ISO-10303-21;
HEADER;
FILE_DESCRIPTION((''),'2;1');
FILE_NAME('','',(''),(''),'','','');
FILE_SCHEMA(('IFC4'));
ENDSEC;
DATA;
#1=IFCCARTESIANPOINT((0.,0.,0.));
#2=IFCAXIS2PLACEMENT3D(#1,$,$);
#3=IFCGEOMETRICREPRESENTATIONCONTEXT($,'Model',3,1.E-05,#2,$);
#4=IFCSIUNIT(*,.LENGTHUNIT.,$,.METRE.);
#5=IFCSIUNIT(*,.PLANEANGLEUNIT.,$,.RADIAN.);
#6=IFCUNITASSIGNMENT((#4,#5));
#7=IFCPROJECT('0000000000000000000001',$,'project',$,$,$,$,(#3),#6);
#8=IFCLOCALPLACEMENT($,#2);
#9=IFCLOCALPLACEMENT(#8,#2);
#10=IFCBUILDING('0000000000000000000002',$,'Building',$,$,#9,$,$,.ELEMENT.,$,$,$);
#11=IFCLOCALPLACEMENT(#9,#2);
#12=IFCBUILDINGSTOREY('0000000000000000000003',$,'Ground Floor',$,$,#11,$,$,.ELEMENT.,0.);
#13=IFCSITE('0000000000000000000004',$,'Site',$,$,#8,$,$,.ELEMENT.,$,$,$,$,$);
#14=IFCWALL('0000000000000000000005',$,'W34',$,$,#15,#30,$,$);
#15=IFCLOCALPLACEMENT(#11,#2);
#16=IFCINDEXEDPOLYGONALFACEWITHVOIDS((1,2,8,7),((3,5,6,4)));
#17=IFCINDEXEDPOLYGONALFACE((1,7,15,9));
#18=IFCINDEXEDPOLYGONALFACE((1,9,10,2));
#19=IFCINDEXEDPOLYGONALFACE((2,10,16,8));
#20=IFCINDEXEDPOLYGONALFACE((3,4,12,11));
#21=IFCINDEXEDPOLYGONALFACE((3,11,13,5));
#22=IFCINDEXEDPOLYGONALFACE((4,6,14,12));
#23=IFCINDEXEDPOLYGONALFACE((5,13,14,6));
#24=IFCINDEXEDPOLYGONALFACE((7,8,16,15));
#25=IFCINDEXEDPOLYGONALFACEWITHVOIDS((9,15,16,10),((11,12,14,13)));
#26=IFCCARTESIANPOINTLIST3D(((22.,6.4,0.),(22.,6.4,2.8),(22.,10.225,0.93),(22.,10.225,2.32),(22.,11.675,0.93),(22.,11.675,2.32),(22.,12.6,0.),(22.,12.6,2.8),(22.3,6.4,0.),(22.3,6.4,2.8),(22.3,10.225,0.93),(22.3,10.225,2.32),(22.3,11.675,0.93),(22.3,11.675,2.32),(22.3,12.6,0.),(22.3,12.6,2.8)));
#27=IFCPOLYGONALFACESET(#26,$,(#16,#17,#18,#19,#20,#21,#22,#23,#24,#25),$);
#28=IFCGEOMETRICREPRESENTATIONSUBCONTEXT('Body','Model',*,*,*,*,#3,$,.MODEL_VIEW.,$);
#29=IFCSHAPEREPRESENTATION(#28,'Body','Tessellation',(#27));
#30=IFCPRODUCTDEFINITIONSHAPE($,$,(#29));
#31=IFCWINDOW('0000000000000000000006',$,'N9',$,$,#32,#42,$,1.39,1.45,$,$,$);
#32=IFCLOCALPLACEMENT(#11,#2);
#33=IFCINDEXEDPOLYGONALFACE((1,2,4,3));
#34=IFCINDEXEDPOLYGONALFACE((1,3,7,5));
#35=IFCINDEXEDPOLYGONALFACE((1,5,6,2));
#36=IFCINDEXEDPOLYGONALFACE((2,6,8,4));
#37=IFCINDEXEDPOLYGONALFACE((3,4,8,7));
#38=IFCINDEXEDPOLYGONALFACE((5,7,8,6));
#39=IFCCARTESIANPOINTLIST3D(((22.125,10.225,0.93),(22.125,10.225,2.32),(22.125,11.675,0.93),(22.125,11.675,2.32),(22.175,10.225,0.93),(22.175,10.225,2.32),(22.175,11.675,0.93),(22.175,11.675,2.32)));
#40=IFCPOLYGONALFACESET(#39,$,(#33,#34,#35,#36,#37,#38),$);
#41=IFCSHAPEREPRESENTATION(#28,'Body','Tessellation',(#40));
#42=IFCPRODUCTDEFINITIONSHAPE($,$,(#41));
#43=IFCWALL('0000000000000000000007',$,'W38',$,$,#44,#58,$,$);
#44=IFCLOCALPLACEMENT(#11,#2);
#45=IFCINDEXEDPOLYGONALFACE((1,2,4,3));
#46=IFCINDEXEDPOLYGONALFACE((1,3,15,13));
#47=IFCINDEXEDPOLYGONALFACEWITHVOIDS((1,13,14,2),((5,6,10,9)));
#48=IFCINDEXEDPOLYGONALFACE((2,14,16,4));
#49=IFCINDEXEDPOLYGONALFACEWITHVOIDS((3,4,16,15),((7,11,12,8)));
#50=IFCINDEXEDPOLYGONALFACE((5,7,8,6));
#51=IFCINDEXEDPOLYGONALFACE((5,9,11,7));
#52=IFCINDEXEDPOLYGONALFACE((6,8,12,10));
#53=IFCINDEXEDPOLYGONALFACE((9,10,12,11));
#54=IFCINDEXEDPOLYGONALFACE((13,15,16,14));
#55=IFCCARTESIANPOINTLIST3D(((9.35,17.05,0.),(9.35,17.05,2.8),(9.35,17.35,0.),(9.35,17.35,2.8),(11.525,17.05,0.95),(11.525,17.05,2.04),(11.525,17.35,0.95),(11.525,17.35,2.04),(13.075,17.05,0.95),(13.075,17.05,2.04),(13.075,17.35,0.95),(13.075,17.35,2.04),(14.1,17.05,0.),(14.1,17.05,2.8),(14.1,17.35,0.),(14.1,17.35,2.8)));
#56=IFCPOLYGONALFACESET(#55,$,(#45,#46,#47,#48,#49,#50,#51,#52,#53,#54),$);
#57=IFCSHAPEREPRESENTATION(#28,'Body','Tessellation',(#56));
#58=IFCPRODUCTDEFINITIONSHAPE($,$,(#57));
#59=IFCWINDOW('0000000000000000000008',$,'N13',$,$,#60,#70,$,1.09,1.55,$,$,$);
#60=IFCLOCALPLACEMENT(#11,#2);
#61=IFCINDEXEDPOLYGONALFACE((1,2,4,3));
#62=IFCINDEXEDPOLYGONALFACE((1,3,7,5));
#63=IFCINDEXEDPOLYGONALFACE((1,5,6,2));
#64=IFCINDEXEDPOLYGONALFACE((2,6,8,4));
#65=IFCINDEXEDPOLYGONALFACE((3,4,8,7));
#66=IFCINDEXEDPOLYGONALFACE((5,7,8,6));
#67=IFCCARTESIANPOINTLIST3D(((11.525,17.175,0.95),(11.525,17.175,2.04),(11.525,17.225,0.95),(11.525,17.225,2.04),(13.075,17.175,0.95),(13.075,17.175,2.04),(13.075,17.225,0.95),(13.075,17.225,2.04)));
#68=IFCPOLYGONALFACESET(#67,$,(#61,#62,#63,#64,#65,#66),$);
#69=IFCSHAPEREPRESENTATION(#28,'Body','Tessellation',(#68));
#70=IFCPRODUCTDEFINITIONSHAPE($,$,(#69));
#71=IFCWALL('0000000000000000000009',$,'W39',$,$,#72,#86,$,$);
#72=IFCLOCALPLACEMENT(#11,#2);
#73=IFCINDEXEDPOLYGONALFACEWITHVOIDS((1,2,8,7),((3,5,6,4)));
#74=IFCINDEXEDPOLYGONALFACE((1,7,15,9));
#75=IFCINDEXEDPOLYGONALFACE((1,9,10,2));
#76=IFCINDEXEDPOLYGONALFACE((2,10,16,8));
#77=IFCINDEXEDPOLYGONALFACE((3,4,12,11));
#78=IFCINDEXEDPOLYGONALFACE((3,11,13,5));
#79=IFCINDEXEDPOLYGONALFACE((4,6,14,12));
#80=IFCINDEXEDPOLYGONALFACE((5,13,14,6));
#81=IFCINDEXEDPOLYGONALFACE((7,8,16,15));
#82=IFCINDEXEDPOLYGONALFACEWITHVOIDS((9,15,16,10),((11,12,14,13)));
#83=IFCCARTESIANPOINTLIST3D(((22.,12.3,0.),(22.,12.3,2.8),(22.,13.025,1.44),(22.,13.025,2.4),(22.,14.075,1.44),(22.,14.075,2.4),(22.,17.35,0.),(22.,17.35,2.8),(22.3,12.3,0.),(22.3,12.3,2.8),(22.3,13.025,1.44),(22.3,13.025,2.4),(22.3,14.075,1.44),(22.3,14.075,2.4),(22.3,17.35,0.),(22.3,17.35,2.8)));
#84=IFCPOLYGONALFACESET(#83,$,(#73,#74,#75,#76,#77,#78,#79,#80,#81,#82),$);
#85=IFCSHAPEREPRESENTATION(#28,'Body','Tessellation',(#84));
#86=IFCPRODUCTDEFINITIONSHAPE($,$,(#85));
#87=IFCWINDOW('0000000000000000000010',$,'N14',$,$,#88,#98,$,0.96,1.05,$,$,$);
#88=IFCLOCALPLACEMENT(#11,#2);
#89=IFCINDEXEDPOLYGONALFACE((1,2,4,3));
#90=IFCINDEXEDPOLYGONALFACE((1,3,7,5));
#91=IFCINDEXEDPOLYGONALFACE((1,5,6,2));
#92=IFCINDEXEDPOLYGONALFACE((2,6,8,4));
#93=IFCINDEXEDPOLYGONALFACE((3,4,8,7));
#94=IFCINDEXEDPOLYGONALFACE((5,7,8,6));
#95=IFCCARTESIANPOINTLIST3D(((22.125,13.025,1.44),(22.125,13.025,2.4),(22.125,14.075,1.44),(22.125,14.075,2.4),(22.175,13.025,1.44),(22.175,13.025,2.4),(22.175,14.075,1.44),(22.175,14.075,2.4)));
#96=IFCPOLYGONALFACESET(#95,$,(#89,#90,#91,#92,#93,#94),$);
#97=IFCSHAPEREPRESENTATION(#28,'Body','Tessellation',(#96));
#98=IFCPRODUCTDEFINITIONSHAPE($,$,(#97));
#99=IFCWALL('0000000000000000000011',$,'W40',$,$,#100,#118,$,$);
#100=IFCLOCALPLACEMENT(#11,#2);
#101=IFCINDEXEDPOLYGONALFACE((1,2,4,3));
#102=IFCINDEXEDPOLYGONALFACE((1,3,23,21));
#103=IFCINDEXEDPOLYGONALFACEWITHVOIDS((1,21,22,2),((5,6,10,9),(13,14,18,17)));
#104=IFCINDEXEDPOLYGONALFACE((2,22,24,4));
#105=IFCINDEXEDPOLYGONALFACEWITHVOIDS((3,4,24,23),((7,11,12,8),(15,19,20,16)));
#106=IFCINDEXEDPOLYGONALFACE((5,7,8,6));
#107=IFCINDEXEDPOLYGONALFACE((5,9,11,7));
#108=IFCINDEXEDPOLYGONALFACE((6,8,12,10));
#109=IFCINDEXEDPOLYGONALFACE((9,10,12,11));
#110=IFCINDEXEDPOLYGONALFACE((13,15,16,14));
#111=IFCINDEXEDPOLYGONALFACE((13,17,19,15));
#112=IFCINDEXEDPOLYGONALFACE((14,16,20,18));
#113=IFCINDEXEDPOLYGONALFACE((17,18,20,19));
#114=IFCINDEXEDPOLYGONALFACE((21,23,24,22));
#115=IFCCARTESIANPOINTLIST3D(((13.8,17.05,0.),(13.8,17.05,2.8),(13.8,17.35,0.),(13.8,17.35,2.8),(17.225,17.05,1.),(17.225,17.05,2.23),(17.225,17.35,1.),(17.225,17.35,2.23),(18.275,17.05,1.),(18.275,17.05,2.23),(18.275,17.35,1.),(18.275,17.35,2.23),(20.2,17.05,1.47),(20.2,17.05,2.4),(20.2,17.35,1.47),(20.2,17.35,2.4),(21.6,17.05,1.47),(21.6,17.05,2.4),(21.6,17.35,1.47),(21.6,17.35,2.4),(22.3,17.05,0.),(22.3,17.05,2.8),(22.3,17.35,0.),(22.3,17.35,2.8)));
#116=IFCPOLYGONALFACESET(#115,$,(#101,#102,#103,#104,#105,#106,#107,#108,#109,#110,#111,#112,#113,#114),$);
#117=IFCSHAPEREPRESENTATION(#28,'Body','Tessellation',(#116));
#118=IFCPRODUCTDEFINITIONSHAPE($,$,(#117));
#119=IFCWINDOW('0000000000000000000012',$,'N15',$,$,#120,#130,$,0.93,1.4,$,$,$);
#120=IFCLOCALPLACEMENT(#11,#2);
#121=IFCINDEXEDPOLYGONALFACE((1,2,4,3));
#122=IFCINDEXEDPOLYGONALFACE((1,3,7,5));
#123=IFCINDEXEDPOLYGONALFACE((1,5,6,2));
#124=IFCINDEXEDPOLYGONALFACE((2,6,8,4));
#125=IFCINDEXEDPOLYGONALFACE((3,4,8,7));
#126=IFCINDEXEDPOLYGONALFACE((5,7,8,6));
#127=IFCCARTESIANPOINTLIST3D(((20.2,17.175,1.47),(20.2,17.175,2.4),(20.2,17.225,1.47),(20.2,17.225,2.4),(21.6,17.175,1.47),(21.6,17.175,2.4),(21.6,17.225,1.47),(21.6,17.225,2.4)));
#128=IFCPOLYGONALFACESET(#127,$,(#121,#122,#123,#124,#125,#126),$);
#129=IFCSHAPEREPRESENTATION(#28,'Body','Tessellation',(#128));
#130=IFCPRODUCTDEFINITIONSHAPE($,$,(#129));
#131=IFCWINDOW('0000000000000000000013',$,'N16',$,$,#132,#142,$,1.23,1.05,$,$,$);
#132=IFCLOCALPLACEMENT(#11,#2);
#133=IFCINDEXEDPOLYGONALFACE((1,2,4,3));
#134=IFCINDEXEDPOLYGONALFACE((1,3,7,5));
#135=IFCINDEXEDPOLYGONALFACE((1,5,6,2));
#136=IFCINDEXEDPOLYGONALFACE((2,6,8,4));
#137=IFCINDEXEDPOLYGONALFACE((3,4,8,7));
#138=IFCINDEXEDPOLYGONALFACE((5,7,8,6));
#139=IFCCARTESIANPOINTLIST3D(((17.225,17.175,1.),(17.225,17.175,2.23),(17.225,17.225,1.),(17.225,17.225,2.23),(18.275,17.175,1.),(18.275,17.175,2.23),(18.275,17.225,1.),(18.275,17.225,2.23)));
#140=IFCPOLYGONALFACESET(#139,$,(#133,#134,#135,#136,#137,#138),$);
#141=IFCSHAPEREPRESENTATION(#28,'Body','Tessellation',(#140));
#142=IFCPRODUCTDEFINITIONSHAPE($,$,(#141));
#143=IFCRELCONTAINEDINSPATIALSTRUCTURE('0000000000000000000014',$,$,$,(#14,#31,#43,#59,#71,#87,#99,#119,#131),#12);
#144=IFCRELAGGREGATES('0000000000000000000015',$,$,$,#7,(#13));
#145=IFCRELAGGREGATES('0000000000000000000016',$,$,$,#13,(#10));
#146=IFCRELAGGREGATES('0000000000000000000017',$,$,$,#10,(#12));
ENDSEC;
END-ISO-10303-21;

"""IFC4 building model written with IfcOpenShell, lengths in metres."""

from ifc_helpers import new_model, si_unit, frame, frame_2d, origin, origin_2d, place, context, subcontext, project, spatial, rectangle, extrude, element, fill, save


model = new_model("IFC4")

# Units and contexts
model_context = context("Model", 3, precision=1e-05, world=origin())
body_context = subcontext(model_context, "Body", "Model", "MODEL_VIEW")
ifc_project = project(units=[si_unit("LENGTHUNIT", "METRE"), si_unit("PLANEANGLEUNIT", "RADIAN")], contexts=[model_context])

# Site, building, storey
site_placement = place(None, origin())
site = spatial("IfcSite", under=ifc_project, at=site_placement, Name="Site", CompositionType="ELEMENT")
building_placement = place(site_placement, origin())
building = spatial("IfcBuilding", under=site, at=building_placement, Name="Building", CompositionType="ELEMENT")
storey_placement = place(building_placement, origin())
storey = spatial("IfcBuildingStorey", under=building, at=storey_placement, Name="Ground Floor", CompositionType="ELEMENT", Elevation=0.0)

# Walls, openings, windows
wall_1_placement = place(storey_placement, frame((22.15, 6.55, 0.0), x_axis=(0.0, 1.0, 0.0)))
wall_1 = element("IfcWall", 1, at=wall_1_placement, inside=storey, Name="W34", context=body_context, shape_type="SweptSolid", body=[
    extrude(rectangle(XDim=6.2, YDim=0.3, at=frame_2d((2.95, 0.0))), origin(), (0.0, 0.0, 1.0), 2.8),
])
opening_1_placement = place(wall_1_placement, frame((4.4, 0.0, 0.93)))
opening_1 = element("IfcOpeningElement", 2, at=opening_1_placement, cuts=wall_1, context=body_context, shape_type="SweptSolid", body=[
    extrude(rectangle(XDim=1.45, YDim=0.4, at=origin_2d()), origin(), (0.0, 0.0, 1.0), 1.39),
])
window_1_placement = place(opening_1_placement, origin())
window_1 = element("IfcWindow", 3, at=window_1_placement, inside=storey, Name="N9", OverallHeight=1.39, OverallWidth=1.45, context=body_context, shape_type="SweptSolid", body=[
    extrude(rectangle(XDim=1.45, YDim=0.05, at=origin_2d()), origin(), (0.0, 0.0, 1.0), 1.39),
])
fill(opening_1, window_1)
wall_2_placement = place(storey_placement, frame((9.5, 17.2, 0.0), x_axis=(1.0, 0.0, 0.0)))
wall_2 = element("IfcWall", 4, at=wall_2_placement, inside=storey, Name="W38", context=body_context, shape_type="SweptSolid", body=[
    extrude(rectangle(XDim=4.75, YDim=0.3, at=frame_2d((2.225, 0.0))), origin(), (0.0, 0.0, 1.0), 2.8),
])
opening_2_placement = place(wall_2_placement, frame((2.8, 0.0, 0.95)))
opening_2 = element("IfcOpeningElement", 5, at=opening_2_placement, cuts=wall_2, context=body_context, shape_type="SweptSolid", body=[
    extrude(rectangle(XDim=1.55, YDim=0.4, at=origin_2d()), origin(), (0.0, 0.0, 1.0), 1.09),
])
window_2_placement = place(opening_2_placement, origin())
window_2 = element("IfcWindow", 6, at=window_2_placement, inside=storey, Name="N13", OverallHeight=1.09, OverallWidth=1.55, context=body_context, shape_type="SweptSolid", body=[
    extrude(rectangle(XDim=1.55, YDim=0.05, at=origin_2d()), origin(), (0.0, 0.0, 1.0), 1.09),
])
fill(opening_2, window_2)
wall_3_placement = place(storey_placement, frame((22.15, 12.45, 0.0), x_axis=(0.0, 1.0, 0.0)))
wall_3 = element("IfcWall", 7, at=wall_3_placement, inside=storey, Name="W39", context=body_context, shape_type="SweptSolid", body=[
    extrude(rectangle(XDim=5.05, YDim=0.3, at=frame_2d((2.375, 0.0))), origin(), (0.0, 0.0, 1.0), 2.8),
])
opening_3_placement = place(wall_3_placement, frame((1.1, 0.0, 1.44)))
opening_3 = element("IfcOpeningElement", 8, at=opening_3_placement, cuts=wall_3, context=body_context, shape_type="SweptSolid", body=[
    extrude(rectangle(XDim=1.05, YDim=0.4, at=origin_2d()), origin(), (0.0, 0.0, 1.0), 0.96),
])
window_3_placement = place(opening_3_placement, origin())
window_3 = element("IfcWindow", 9, at=window_3_placement, inside=storey, Name="N14", OverallHeight=0.96, OverallWidth=1.05, context=body_context, shape_type="SweptSolid", body=[
    extrude(rectangle(XDim=1.05, YDim=0.05, at=origin_2d()), origin(), (0.0, 0.0, 1.0), 0.96),
])
fill(opening_3, window_3)

# Wall, openings, windows
wall_4_placement = place(storey_placement, frame((13.95, 17.2, 0.0), x_axis=(1.0, 0.0, 0.0)))
wall_4 = element("IfcWall", 10, at=wall_4_placement, inside=storey, Name="W40", context=body_context, shape_type="SweptSolid", body=[
    extrude(rectangle(XDim=8.5, YDim=0.3, at=frame_2d((4.1, 0.0))), origin(), (0.0, 0.0, 1.0), 2.8),
])
opening_4_placement = place(wall_4_placement, frame((6.95, 0.0, 1.47)))
opening_4 = element("IfcOpeningElement", 11, at=opening_4_placement, cuts=wall_4, context=body_context, shape_type="SweptSolid", body=[
    extrude(rectangle(XDim=1.4, YDim=0.4, at=origin_2d()), origin(), (0.0, 0.0, 1.0), 0.93),
])
opening_5_placement = place(wall_4_placement, frame((3.8, 0.0, 1.0)))
opening_5 = element("IfcOpeningElement", 12, at=opening_5_placement, cuts=wall_4, context=body_context, shape_type="SweptSolid", body=[
    extrude(rectangle(XDim=1.05, YDim=0.4, at=origin_2d()), origin(), (0.0, 0.0, 1.0), 1.23),
])
window_4_placement = place(opening_4_placement, origin())
window_4 = element("IfcWindow", 13, at=window_4_placement, inside=storey, Name="N15", OverallHeight=0.93, OverallWidth=1.4, context=body_context, shape_type="SweptSolid", body=[
    extrude(rectangle(XDim=1.4, YDim=0.05, at=origin_2d()), origin(), (0.0, 0.0, 1.0), 0.93),
])
fill(opening_4, window_4)
window_5_placement = place(opening_5_placement, origin())
window_5 = element("IfcWindow", 14, at=window_5_placement, inside=storey, Name="N16", OverallHeight=1.23, OverallWidth=1.05, context=body_context, shape_type="SweptSolid", body=[
    extrude(rectangle(XDim=1.05, YDim=0.05, at=origin_2d()), origin(), (0.0, 0.0, 1.0), 1.23),
])
fill(opening_5, window_5)

save(model, "model.ifc")
